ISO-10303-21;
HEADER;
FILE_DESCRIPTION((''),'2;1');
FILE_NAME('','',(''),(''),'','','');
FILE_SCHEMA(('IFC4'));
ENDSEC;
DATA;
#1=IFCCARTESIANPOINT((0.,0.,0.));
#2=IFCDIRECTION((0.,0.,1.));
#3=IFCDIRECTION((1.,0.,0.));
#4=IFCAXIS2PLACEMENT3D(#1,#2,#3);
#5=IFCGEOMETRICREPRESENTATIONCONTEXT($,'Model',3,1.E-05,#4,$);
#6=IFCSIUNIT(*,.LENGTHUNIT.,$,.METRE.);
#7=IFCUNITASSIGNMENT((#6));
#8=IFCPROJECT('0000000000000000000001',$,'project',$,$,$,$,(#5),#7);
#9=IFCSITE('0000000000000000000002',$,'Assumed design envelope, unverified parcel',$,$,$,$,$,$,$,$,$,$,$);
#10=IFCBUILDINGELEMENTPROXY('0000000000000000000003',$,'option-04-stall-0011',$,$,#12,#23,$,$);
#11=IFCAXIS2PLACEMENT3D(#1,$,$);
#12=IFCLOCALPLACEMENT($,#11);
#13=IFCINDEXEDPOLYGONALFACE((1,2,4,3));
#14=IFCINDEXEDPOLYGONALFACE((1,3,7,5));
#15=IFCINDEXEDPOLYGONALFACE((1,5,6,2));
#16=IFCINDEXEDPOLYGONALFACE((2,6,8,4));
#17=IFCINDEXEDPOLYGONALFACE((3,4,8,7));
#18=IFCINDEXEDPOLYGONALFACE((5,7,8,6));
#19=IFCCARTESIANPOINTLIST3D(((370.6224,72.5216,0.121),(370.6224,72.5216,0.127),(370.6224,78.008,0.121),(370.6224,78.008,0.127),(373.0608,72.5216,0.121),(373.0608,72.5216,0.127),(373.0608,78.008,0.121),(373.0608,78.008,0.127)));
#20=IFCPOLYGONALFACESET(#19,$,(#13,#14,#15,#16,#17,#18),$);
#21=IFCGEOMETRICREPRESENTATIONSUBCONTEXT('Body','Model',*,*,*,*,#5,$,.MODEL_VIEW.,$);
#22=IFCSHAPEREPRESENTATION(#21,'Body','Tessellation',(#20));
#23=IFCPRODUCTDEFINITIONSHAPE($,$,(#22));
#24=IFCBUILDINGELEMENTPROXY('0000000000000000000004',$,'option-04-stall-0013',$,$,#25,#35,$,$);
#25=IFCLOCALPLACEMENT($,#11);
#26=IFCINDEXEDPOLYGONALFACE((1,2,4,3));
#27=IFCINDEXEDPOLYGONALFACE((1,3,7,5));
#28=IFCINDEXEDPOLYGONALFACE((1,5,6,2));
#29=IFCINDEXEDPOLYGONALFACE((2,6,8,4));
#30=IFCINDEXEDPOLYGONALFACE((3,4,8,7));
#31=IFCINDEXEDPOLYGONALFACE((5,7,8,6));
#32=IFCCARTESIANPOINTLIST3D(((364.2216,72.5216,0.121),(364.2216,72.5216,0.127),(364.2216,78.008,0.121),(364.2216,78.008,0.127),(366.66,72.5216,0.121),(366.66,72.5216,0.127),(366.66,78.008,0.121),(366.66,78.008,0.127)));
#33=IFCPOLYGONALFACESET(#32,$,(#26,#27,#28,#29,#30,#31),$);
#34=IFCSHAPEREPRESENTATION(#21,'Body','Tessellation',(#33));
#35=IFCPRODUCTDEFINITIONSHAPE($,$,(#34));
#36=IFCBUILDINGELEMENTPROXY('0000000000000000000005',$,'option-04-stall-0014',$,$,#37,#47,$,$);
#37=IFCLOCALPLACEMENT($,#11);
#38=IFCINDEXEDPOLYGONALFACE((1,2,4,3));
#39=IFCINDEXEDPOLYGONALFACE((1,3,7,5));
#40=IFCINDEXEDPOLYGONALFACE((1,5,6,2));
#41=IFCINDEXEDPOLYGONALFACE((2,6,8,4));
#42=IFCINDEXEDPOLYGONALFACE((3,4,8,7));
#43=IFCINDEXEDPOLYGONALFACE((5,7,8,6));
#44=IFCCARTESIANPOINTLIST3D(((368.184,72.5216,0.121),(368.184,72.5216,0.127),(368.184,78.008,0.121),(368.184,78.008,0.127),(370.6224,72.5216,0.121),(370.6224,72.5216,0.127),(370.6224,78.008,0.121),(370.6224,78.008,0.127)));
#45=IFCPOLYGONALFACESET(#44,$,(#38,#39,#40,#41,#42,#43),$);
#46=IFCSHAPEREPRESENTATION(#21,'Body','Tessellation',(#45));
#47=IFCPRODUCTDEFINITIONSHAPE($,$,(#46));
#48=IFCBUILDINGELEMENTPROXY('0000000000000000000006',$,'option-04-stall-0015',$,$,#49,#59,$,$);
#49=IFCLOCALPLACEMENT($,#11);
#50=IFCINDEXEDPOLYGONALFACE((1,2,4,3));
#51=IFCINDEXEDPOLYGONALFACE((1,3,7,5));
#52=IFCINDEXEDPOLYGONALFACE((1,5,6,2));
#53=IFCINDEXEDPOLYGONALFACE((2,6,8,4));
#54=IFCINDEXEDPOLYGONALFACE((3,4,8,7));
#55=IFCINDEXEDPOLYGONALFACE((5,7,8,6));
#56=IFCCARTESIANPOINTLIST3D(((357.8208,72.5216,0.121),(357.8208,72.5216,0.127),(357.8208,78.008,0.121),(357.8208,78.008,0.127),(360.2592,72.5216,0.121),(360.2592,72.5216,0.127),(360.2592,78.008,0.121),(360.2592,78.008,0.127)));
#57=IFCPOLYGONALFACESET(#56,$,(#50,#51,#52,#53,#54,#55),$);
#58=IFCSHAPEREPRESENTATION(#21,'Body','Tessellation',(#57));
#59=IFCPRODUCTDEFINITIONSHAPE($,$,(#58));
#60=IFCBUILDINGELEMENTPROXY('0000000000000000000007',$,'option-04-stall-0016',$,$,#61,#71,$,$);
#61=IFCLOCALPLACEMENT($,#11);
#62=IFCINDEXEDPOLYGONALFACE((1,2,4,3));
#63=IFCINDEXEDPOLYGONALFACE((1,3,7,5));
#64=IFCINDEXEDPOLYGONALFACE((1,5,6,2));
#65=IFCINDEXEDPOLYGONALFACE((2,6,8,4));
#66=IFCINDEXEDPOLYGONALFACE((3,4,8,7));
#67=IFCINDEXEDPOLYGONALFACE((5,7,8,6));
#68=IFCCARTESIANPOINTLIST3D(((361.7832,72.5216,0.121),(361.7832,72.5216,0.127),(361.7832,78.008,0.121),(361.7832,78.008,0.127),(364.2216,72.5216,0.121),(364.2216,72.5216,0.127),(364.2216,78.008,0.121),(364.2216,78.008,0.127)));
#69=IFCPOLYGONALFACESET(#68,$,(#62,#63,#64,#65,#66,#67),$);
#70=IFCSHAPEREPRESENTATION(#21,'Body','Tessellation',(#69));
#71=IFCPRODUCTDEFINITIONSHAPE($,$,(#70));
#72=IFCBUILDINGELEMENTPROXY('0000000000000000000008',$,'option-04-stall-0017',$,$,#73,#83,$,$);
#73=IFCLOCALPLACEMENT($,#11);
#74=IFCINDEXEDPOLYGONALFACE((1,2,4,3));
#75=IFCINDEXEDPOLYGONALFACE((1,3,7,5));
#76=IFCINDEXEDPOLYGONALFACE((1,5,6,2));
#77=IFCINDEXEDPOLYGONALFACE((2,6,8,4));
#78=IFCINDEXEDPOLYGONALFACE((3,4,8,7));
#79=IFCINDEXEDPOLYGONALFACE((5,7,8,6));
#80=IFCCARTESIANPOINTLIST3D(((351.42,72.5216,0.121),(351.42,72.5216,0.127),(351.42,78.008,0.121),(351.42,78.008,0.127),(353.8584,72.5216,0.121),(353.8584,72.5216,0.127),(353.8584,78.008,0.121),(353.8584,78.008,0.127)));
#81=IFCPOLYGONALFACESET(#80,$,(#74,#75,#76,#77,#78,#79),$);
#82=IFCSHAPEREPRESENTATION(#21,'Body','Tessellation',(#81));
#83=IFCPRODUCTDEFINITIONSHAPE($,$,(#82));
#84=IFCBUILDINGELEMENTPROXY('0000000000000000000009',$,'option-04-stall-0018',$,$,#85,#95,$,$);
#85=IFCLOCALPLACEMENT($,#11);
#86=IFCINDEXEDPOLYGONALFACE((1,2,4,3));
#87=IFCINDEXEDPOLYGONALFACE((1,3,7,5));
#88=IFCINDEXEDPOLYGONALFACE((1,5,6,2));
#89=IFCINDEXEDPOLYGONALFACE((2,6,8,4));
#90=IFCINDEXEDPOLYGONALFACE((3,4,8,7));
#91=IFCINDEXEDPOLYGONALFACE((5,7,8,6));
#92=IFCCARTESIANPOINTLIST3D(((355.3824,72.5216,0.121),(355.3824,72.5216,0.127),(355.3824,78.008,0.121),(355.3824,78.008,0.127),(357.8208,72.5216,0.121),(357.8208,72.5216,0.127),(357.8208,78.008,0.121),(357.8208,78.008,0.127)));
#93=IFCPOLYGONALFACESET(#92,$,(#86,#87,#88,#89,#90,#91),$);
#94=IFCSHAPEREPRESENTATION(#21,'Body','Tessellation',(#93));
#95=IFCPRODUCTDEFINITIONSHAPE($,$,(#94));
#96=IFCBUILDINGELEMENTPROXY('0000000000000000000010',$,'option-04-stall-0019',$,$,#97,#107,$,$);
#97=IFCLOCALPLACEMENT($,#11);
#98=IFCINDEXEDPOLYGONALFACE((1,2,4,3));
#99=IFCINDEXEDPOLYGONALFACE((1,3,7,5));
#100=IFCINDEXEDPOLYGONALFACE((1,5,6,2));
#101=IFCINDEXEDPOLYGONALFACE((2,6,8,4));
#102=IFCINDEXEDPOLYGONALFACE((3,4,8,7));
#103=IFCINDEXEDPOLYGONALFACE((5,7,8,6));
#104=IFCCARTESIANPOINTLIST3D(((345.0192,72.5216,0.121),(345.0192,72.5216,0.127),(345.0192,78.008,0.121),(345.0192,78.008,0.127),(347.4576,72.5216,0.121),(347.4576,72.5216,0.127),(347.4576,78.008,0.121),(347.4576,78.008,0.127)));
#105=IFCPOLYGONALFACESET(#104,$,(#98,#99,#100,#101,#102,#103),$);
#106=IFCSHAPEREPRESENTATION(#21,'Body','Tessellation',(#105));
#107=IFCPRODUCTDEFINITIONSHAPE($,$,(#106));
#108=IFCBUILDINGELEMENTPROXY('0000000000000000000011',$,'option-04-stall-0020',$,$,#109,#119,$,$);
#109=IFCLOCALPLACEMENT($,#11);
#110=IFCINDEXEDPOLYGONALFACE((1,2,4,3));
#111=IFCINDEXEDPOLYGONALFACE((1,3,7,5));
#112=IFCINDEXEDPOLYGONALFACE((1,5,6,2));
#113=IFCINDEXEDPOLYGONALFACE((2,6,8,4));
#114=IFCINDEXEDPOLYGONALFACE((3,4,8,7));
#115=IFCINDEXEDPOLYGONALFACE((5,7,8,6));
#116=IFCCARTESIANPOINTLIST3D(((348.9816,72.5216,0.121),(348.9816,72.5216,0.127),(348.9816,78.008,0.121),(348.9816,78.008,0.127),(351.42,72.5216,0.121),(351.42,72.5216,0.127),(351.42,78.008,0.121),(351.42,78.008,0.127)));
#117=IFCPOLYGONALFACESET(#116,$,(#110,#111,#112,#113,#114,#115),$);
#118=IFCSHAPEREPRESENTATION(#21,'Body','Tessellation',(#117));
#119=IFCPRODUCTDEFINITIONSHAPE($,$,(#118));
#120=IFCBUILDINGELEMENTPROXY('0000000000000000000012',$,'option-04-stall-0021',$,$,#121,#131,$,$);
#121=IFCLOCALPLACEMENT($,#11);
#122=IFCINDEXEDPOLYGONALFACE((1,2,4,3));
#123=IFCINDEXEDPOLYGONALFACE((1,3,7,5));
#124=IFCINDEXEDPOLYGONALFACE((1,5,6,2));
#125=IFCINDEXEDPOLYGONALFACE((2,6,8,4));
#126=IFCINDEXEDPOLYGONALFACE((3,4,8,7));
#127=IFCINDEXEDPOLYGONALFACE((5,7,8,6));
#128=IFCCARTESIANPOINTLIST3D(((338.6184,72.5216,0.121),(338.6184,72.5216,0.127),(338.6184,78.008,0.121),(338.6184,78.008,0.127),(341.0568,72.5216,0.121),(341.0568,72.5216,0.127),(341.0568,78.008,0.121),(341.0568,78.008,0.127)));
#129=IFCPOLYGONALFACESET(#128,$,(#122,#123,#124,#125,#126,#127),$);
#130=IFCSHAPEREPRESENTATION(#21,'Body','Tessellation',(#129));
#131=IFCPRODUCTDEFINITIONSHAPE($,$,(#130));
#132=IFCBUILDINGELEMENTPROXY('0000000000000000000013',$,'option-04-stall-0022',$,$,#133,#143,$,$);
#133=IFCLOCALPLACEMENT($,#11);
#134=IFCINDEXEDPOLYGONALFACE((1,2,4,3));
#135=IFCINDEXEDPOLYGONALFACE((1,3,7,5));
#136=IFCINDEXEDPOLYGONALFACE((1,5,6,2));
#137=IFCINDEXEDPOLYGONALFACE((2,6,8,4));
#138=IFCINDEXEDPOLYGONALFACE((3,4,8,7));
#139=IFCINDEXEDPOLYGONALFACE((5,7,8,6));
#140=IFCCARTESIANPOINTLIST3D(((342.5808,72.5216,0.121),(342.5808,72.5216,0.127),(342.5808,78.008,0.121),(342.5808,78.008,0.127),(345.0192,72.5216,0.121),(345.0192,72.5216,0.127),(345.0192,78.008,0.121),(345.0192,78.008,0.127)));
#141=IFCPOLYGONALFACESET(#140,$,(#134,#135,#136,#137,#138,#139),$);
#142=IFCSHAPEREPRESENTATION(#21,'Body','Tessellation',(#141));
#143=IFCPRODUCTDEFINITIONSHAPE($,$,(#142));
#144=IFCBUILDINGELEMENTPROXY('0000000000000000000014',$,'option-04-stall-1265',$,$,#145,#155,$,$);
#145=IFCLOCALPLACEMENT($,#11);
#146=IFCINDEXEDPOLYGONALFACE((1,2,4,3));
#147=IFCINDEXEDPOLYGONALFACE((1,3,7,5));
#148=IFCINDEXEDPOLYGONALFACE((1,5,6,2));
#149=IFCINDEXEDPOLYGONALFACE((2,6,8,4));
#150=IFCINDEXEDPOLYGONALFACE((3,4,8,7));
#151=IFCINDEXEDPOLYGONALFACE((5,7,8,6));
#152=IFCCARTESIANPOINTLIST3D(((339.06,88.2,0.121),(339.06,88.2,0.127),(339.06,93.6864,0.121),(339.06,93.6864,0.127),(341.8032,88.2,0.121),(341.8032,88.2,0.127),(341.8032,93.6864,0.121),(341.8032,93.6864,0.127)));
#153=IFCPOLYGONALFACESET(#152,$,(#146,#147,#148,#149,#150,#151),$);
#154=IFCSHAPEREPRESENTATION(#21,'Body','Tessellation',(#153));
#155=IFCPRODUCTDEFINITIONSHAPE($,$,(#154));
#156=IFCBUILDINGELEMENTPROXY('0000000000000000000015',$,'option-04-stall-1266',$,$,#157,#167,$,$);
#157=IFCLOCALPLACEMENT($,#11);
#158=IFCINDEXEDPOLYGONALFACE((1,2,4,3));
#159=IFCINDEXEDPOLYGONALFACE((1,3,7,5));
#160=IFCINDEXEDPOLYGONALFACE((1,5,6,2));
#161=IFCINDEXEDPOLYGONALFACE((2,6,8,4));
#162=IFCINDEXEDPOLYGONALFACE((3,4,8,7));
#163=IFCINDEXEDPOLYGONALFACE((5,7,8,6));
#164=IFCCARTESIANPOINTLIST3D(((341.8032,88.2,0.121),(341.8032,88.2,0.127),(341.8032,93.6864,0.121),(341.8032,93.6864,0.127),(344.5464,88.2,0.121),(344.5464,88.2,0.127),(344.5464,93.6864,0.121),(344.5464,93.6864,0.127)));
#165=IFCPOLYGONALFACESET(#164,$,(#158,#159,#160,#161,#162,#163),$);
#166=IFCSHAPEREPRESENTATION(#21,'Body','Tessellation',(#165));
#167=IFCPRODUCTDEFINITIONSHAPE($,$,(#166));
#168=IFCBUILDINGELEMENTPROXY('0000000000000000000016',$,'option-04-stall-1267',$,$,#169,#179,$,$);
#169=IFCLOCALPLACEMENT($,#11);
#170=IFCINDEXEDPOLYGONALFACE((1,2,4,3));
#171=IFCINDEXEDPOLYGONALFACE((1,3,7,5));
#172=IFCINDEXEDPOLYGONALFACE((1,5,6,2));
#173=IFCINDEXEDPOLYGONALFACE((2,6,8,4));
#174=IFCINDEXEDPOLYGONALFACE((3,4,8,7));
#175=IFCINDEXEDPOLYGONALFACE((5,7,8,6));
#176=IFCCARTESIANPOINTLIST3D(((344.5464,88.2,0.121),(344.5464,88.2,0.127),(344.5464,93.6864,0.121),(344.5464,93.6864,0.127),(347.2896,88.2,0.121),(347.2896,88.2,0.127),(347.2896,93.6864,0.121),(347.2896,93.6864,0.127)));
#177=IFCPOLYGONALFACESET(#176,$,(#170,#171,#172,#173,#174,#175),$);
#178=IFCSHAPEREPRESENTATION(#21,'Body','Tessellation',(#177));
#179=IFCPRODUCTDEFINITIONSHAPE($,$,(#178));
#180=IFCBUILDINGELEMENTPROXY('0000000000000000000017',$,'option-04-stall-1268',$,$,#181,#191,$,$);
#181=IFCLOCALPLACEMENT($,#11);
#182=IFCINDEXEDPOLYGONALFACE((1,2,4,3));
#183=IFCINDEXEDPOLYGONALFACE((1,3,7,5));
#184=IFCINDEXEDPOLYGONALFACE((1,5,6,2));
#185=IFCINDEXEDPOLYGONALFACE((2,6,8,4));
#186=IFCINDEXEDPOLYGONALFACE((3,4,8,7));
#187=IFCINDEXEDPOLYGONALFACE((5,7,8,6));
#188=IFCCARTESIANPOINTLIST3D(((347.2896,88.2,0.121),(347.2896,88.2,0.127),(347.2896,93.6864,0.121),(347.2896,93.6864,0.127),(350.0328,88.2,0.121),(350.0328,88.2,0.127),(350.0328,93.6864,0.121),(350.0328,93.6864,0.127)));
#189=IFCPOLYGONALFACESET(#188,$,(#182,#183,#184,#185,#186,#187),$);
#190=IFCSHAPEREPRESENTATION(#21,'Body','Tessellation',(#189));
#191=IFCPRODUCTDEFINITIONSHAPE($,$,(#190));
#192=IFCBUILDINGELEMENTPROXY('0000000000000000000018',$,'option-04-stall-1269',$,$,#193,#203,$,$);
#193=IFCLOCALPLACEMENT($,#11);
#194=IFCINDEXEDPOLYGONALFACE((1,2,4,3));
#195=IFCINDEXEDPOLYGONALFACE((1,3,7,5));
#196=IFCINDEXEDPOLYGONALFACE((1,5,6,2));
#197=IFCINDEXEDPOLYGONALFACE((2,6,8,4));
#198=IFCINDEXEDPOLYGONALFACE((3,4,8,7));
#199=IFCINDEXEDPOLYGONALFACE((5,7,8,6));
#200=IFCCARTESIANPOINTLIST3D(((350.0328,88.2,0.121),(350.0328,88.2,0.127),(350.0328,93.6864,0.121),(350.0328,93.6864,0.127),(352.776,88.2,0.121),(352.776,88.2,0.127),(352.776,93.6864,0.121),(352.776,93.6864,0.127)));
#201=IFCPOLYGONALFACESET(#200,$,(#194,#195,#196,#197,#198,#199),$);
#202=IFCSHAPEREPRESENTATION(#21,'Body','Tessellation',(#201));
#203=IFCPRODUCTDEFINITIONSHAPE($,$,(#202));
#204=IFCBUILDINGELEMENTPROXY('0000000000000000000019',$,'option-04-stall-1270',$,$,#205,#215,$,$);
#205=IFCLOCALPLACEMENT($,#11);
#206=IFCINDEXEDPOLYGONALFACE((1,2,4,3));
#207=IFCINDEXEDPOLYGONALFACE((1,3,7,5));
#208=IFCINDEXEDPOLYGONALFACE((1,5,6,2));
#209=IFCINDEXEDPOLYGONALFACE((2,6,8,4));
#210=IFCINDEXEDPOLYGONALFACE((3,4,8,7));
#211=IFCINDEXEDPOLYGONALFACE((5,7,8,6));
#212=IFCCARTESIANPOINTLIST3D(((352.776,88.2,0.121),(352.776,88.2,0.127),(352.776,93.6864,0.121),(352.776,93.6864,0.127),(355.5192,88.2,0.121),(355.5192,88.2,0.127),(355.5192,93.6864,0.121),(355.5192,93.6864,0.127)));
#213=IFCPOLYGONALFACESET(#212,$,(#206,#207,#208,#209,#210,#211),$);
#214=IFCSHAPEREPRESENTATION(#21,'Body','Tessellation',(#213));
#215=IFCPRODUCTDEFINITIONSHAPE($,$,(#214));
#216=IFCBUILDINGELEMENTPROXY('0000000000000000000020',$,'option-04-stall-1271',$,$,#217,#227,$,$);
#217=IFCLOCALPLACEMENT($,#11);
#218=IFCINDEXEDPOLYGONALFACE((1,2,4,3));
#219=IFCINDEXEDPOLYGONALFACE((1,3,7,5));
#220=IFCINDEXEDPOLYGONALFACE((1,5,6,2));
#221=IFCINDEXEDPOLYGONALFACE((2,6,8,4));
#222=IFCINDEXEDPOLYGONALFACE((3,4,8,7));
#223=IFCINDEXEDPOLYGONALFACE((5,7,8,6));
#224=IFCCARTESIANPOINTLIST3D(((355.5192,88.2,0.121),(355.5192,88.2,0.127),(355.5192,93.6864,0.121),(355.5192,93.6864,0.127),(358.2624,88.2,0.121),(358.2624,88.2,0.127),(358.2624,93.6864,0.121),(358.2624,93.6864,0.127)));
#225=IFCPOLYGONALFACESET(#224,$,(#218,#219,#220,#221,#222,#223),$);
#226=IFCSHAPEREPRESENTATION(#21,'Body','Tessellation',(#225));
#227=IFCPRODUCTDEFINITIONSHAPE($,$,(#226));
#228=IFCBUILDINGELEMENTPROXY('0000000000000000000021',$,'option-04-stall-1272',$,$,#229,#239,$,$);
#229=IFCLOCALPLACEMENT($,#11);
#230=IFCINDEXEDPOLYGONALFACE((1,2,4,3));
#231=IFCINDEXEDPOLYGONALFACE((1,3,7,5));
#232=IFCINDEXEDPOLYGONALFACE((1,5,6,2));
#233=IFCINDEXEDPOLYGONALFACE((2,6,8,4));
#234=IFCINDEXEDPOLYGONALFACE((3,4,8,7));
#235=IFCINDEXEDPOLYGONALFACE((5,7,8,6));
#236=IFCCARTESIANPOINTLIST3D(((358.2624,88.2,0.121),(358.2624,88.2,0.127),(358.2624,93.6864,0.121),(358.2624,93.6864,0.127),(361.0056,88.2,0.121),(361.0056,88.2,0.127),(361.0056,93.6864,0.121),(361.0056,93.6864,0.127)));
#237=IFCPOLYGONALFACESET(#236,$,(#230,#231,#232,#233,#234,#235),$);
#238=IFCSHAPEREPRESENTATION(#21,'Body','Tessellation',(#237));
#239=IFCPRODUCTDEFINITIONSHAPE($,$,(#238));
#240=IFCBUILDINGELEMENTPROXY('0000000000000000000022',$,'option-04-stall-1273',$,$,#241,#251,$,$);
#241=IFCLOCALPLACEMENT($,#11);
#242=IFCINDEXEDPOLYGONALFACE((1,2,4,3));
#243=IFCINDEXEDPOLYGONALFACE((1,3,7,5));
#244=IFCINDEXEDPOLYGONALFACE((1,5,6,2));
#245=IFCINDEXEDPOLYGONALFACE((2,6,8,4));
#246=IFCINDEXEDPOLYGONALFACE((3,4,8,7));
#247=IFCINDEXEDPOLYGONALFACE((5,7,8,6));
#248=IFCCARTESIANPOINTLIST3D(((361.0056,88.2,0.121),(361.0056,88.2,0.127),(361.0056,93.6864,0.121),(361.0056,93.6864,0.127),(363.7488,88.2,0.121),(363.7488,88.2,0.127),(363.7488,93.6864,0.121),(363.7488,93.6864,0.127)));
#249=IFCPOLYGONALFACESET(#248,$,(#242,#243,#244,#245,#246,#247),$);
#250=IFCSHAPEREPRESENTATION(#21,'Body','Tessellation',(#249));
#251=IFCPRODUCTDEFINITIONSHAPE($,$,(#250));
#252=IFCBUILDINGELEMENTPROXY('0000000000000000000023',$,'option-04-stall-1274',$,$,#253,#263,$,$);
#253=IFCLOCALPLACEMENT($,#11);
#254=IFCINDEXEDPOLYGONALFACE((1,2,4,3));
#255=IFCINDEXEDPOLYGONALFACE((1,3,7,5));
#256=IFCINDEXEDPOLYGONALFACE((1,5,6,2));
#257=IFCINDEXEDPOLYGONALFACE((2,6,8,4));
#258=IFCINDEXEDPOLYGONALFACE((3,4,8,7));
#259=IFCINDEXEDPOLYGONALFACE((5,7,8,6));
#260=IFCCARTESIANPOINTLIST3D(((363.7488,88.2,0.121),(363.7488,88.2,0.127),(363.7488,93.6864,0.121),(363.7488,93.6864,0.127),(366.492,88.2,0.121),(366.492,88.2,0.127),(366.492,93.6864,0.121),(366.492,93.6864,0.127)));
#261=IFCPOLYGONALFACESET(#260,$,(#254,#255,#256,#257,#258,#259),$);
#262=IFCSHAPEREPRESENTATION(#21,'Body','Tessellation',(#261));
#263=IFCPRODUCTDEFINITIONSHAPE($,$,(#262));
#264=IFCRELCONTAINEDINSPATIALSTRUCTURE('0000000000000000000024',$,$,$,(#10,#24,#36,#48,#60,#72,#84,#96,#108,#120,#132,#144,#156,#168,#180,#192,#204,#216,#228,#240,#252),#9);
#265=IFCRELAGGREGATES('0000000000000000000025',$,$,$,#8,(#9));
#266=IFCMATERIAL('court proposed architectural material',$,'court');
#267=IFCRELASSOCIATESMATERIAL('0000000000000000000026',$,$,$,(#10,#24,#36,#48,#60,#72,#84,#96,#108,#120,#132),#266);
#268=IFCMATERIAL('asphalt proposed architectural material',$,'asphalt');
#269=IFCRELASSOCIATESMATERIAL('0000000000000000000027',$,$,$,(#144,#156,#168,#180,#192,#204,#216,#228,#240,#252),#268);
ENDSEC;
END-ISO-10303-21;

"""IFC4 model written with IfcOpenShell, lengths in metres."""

from ifc_helpers import new_model, si_unit, frame, origin_with_axes, place, context, subcontext, project, spatial, rectangle, extrude, material, element, save


model = new_model("IFC4")

# Units and contexts
model_context = context("Model", 3, precision=1e-05, world=origin_with_axes())
body_context = subcontext(model_context, "Body", "Model", "MODEL_VIEW")
ifc_project = project(units=[si_unit("LENGTHUNIT", "METRE")], contexts=[model_context])

# Site
site = spatial("IfcSite", under=ifc_project, Name="Assumed design envelope, unverified parcel")

# Building element proxies
ifc_material_1 = material(Name="court proposed architectural material", Category="court")
for number, where, z_axis, x_axis, name in (
    (1, (371.8416, 75.2648, 0.121), (0.0, 0.0, 1.0), (1.0, 0.0, 0.0), "option-04-stall-0011"),
    (2, (365.4408, 75.2648, 0.121), (0.0, 0.0, 1.0), (1.0, 0.0, 0.0), "option-04-stall-0013"),
    (3, (369.4032, 75.2648, 0.121), (0.0, 0.0, 1.0), (1.0, 0.0, 0.0), "option-04-stall-0014"),
    (4, (359.04, 75.2648, 0.121), (0.0, 0.0, 1.0), (1.0, 0.0, 0.0), "option-04-stall-0015"),
    (5, (363.0024, 75.2648, 0.121), (0.0, 0.0, 1.0), (1.0, 0.0, 0.0), "option-04-stall-0016"),
    (6, (352.6392, 75.2648, 0.121), (0.0, 0.0, 1.0), (1.0, 0.0, 0.0), "option-04-stall-0017"),
    (7, (356.6016, 75.2648, 0.121), (0.0, 0.0, 1.0), (1.0, 0.0, 0.0), "option-04-stall-0018"),
    (8, (346.2384, 75.2648, 0.121), (0.0, 0.0, 1.0), (1.0, 0.0, 0.0), "option-04-stall-0019"),
    (9, (350.2008, 75.2648, 0.121), (0.0, 0.0, 1.0), (1.0, 0.0, 0.0), "option-04-stall-0020"),
    (10, (339.8376, 75.2648, 0.121), (0.0, 0.0, 1.0), (1.0, 0.0, 0.0), "option-04-stall-0021"),
    (11, (343.8, 75.2648, 0.121), (0.0, 0.0, 1.0), (1.0, 0.0, 0.0), "option-04-stall-0022"),
):
    element("IfcBuildingElementProxy", number, at=place(None, frame(where, z_axis=z_axis, x_axis=x_axis)), inside=site, material=ifc_material_1, Name=name, context=body_context, shape_type="SweptSolid", body=[
        extrude(rectangle(XDim=2.4384, YDim=5.4864), origin_with_axes(), (0.0, 0.0, 1.0), 0.006),
    ])
ifc_material_2 = material(Name="asphalt proposed architectural material", Category="asphalt")
for number, where, z_axis, x_axis, name in (
    (12, (340.4316, 90.9432, 0.121), (0.0, 0.0, 1.0), (1.0, 0.0, 0.0), "option-04-stall-1265"),
    (13, (343.1748, 90.9432, 0.121), (0.0, 0.0, 1.0), (1.0, 0.0, 0.0), "option-04-stall-1266"),
    (14, (345.918, 90.9432, 0.121), (0.0, 0.0, 1.0), (1.0, 0.0, 0.0), "option-04-stall-1267"),
    (15, (348.6612, 90.9432, 0.121), (0.0, 0.0, 1.0), (1.0, 0.0, 0.0), "option-04-stall-1268"),
    (16, (351.4044, 90.9432, 0.121), (0.0, 0.0, 1.0), (1.0, 0.0, 0.0), "option-04-stall-1269"),
    (17, (354.1476, 90.9432, 0.121), (0.0, 0.0, 1.0), (1.0, 0.0, 0.0), "option-04-stall-1270"),
    (18, (356.8908, 90.9432, 0.121), (0.0, 0.0, 1.0), (1.0, 0.0, 0.0), "option-04-stall-1271"),
    (19, (359.634, 90.9432, 0.121), (0.0, 0.0, 1.0), (1.0, 0.0, 0.0), "option-04-stall-1272"),
    (20, (362.3772, 90.9432, 0.121), (0.0, 0.0, 1.0), (1.0, 0.0, 0.0), "option-04-stall-1273"),
    (21, (365.1204, 90.9432, 0.121), (0.0, 0.0, 1.0), (1.0, 0.0, 0.0), "option-04-stall-1274"),
):
    element("IfcBuildingElementProxy", number, at=place(None, frame(where, z_axis=z_axis, x_axis=x_axis)), inside=site, material=ifc_material_2, Name=name, context=body_context, shape_type="SweptSolid", body=[
        extrude(rectangle(XDim=2.7432, YDim=5.4864), origin_with_axes(), (0.0, 0.0, 1.0), 0.006),
    ])

save(model, "model.ifc")
